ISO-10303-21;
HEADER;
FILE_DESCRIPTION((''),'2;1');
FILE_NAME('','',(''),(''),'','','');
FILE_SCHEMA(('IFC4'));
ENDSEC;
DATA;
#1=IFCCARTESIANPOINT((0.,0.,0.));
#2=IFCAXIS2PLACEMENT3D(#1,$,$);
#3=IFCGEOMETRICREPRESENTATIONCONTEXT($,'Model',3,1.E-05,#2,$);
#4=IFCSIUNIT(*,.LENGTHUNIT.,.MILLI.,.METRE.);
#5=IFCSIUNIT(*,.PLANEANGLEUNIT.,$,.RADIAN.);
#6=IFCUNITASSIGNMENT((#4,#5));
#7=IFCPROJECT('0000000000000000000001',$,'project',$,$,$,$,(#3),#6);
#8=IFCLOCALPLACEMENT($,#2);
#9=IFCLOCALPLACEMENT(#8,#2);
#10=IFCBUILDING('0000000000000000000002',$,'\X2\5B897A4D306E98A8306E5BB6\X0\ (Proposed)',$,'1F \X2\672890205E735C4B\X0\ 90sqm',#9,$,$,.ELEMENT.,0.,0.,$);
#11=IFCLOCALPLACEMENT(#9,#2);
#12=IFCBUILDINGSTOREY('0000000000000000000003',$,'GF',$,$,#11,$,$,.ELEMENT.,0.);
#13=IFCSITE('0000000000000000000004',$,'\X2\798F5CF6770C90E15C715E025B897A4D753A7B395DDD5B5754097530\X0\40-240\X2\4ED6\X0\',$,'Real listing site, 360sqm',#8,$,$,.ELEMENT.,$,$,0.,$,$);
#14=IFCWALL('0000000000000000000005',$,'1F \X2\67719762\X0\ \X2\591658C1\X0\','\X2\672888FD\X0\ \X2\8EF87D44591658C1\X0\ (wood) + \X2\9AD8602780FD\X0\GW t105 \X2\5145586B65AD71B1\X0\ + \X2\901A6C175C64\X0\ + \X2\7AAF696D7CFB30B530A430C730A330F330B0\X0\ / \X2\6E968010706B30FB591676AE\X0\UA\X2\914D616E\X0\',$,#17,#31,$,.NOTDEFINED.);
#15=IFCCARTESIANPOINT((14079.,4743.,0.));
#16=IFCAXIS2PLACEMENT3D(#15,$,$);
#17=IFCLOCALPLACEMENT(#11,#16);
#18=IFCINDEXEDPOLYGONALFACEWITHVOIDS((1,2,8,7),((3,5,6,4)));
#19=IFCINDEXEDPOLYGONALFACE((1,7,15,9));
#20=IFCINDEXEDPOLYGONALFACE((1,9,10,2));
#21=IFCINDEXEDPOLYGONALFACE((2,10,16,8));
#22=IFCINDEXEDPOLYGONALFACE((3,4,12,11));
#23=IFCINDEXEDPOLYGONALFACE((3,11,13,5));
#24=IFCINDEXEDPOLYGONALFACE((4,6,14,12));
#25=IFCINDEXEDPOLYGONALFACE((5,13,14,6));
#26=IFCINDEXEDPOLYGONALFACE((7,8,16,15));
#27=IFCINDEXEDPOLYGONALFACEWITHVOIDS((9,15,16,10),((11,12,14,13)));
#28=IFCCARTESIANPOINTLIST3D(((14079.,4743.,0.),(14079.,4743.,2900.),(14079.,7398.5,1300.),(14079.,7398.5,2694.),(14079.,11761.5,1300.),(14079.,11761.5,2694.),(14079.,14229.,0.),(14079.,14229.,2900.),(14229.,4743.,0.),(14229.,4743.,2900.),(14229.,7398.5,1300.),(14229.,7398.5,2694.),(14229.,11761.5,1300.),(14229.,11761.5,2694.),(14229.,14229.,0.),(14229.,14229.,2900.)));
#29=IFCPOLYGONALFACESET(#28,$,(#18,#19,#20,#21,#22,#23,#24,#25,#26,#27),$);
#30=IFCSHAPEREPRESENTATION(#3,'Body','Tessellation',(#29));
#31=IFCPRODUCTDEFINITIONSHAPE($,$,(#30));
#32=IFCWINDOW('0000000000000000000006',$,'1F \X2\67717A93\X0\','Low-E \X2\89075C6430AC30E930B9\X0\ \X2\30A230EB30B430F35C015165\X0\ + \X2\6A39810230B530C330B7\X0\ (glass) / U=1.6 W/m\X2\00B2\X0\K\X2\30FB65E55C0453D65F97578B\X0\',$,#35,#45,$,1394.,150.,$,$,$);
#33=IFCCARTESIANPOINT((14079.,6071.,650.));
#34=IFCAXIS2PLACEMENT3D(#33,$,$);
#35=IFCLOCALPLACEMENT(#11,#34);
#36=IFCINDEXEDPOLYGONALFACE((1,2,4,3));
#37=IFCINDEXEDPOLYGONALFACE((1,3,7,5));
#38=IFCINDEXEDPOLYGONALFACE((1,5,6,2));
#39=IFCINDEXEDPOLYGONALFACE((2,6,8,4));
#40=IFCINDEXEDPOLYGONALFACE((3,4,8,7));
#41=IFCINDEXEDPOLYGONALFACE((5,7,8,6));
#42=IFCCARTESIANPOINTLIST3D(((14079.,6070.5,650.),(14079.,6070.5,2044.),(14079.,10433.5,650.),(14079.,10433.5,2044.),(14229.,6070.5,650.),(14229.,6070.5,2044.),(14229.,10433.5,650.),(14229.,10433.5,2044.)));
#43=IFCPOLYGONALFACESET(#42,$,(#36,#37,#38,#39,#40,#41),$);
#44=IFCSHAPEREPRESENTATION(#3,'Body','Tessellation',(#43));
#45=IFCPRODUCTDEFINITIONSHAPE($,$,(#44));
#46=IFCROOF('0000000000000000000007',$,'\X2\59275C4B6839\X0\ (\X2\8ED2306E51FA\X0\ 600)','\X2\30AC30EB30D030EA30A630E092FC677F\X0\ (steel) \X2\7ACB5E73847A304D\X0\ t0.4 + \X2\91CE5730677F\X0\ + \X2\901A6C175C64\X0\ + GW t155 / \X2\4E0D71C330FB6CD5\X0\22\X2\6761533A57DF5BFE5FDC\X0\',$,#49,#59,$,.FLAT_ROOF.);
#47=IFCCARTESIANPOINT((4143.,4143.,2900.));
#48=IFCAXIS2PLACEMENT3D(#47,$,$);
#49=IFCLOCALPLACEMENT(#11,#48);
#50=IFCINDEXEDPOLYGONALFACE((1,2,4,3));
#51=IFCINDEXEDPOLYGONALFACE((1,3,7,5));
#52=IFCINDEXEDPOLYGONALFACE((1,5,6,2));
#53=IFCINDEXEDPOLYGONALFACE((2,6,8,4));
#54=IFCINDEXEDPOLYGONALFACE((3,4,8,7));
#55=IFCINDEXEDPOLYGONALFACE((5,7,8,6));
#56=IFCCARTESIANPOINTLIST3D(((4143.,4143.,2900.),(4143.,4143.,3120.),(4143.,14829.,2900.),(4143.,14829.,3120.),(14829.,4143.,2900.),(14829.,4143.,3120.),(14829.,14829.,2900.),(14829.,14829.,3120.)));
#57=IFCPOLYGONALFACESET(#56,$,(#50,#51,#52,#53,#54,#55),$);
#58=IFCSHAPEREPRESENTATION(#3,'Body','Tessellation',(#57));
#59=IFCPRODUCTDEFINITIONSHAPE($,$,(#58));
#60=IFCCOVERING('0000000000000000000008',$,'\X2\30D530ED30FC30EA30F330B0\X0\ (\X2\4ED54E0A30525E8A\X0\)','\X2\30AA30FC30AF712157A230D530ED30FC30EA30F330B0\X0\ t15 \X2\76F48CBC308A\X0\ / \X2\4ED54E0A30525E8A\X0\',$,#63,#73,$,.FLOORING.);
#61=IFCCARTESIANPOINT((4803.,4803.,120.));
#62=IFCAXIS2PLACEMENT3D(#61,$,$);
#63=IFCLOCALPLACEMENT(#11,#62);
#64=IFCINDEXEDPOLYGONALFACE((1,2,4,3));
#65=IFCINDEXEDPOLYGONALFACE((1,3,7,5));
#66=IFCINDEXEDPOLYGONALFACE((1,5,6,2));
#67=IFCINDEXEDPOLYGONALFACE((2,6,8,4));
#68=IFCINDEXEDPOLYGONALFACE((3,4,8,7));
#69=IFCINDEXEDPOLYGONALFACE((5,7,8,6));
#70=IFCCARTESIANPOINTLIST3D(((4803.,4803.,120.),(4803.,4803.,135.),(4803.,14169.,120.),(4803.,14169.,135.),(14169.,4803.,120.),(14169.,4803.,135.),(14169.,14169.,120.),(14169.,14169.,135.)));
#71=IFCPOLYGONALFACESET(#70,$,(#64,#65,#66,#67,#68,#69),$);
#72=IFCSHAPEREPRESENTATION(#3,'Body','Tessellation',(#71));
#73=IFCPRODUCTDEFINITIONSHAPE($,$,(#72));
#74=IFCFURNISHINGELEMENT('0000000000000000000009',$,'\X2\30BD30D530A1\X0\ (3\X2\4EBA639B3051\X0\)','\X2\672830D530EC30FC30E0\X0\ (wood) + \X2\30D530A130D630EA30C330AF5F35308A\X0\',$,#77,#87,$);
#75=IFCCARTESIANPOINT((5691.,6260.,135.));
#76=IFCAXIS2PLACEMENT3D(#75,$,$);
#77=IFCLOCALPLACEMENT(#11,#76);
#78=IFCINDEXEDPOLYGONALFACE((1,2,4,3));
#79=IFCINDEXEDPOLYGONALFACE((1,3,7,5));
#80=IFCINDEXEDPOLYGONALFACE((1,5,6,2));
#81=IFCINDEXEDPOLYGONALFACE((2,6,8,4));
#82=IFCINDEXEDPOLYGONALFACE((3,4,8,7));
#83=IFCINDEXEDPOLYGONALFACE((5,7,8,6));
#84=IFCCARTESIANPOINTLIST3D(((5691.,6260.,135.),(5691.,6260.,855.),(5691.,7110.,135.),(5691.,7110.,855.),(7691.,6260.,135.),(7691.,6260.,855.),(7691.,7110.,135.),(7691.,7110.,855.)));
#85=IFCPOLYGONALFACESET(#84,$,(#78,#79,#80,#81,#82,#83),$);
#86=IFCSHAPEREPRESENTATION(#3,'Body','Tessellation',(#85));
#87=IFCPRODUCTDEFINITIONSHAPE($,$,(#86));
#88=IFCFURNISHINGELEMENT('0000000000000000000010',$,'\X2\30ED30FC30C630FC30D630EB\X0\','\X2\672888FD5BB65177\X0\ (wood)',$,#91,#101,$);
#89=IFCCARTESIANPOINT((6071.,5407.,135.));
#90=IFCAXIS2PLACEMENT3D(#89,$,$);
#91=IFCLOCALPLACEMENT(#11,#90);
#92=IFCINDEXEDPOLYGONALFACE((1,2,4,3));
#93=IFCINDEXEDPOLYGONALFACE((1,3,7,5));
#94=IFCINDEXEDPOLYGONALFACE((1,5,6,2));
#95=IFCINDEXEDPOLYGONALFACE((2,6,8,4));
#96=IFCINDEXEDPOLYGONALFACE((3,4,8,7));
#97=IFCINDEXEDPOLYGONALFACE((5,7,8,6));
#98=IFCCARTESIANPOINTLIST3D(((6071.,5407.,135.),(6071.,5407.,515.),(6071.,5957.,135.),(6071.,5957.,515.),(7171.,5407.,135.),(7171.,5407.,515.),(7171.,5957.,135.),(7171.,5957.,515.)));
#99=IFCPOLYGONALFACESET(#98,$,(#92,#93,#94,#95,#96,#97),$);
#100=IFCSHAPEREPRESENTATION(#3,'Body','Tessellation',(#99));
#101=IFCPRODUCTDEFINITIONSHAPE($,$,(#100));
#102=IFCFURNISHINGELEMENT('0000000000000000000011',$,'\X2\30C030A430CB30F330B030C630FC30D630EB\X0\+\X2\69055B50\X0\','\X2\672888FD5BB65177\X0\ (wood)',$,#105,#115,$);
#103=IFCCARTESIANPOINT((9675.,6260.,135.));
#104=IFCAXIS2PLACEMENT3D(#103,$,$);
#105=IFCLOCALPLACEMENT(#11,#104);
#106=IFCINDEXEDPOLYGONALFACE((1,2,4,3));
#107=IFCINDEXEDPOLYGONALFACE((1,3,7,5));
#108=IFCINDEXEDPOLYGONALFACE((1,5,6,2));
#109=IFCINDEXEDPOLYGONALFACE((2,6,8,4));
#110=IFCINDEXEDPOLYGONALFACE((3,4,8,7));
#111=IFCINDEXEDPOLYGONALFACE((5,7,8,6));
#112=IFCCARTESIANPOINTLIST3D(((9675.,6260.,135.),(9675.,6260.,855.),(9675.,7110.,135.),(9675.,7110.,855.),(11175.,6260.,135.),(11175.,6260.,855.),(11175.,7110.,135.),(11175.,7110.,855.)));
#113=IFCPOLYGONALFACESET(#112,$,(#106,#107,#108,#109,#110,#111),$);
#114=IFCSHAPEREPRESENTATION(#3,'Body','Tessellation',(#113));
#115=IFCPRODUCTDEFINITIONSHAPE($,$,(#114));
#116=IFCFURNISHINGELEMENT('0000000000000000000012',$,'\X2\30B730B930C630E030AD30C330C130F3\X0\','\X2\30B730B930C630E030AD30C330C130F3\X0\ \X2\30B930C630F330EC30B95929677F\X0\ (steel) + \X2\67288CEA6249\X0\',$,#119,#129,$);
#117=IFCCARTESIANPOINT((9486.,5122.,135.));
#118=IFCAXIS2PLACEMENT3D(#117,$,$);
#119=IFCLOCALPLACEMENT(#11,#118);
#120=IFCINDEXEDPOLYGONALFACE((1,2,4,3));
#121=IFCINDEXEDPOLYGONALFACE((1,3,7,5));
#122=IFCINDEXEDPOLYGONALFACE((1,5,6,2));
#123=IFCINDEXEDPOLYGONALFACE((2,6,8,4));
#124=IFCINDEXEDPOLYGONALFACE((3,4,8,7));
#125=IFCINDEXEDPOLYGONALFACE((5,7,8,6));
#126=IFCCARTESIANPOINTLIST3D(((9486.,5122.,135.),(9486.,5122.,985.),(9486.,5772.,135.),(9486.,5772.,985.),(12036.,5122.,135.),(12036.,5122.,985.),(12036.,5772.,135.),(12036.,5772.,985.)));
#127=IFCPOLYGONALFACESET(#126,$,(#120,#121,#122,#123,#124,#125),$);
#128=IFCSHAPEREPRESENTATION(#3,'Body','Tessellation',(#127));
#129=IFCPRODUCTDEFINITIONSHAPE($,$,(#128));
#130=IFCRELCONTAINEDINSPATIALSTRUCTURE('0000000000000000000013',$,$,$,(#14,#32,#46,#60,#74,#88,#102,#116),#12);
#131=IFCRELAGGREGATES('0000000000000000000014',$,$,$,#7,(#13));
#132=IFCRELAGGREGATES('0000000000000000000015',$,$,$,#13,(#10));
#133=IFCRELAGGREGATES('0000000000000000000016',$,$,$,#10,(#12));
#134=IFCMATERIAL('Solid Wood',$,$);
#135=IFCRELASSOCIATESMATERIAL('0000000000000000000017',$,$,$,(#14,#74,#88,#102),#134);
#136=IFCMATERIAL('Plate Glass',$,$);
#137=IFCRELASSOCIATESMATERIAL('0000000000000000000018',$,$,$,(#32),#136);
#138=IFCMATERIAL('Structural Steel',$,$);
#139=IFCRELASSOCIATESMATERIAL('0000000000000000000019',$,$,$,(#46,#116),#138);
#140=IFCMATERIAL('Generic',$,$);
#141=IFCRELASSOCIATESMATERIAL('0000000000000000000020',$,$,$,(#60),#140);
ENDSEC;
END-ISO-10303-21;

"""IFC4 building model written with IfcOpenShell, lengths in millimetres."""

from ifc_helpers import new_model, si_unit, frame, frame_2d, origin, place, context, project, spatial, rectangle, extrude, material, element, fill, save


model = new_model("IFC4")

# Units and contexts
model_context = context("Model", 3, precision=1e-05, world=origin())
ifc_project = project(units=[si_unit("LENGTHUNIT", "METRE", prefix="MILLI"), si_unit("PLANEANGLEUNIT", "RADIAN")], contexts=[model_context])

# Site, building, storey
site_placement = place(None, origin())
site = spatial("IfcSite", under=ifc_project, at=site_placement, Name="福島県郡山市安積町笹川字吉田40-240他", ObjectType="Real listing site, 360sqm", CompositionType="ELEMENT", RefElevation=0.0)
building_placement = place(site_placement, origin())
building = spatial("IfcBuilding", under=site, at=building_placement, Name="安積の風の家 (Proposed)", ObjectType="1F 木造平屋 90sqm", CompositionType="ELEMENT", ElevationOfRefHeight=0.0, ElevationOfTerrain=0.0)
storey_placement = place(building_placement, origin())
storey = spatial("IfcBuildingStorey", under=building, at=storey_placement, Name="GF", CompositionType="ELEMENT", Elevation=0.0)

# Shared definitions
ifc_material_1 = material(Name="Solid Wood")

# Shared definitions
ifc_material_2 = material(Name="Plate Glass")

# Wall, opening, window
wall_1_placement = place(storey_placement, frame((14079.0, 4743.0, 0.0)))
wall_1 = element("IfcWall", 1, at=wall_1_placement, inside=storey, material=ifc_material_1, Name="1F 東面 外壁", Description="木製 軸組外壁 (wood) + 高性能GW t105 充填断熱 + 通気層 + 窯業系サイディング / 準耐火・外皮UA配慮", PredefinedType="NOTDEFINED", context=model_context, shape_type="SweptSolid", body=[
    extrude(rectangle(XDim=150.0, YDim=9486.0, at=frame_2d((75.0, 4743.0))), frame((14079.0, 4743.0, 0.0)), (0.0, 0.0, 1.0), 2900.0),
])
opening_1_placement = place(storey_placement, frame((14079.0, 6071.0, 650.0)))
opening_1 = element("IfcOpeningElement", 2, at=opening_1_placement, cuts=wall_1, PredefinedType="NOTDEFINED", context=model_context, shape_type="SweptSolid", body=[
    extrude(rectangle(XDim=150.0, YDim=4363.0, at=frame_2d((75.0, 2181.0))), frame((14079.0, 6071.0, 650.0)), (0.0, 0.0, 1.0), 1394.0),
])
window_1_placement = place(storey_placement, frame((14079.0, 6071.0, 650.0)))
window_1 = element("IfcWindow", 3, at=window_1_placement, inside=storey, material=ifc_material_2, Name="1F 東窓", Description="Low-E 複層ガラス アルゴン封入 + 樹脂サッシ (glass) / U=1.6 W/m²K・日射取得型", OverallHeight=1394.0, OverallWidth=150.0, context=model_context, shape_type="SweptSolid", body=[
    extrude(rectangle(XDim=150.0, YDim=4363.0, at=frame_2d((75.0, 2181.0))), frame((14079.0, 6071.0, 650.0)), (0.0, 0.0, 1.0), 1394.0),
])
fill(opening_1, window_1)

# Roof
ifc_material_3 = material(Name="Structural Steel")
roof_placement = place(storey_placement, frame((4143.0, 4143.0, 2900.0)))
element("IfcRoof", 4, at=roof_placement, inside=storey, material=ifc_material_3, Name="大屋根 (軒の出 600)", Description="ガルバリウム鋼板 (steel) 立平葺き t0.4 + 野地板 + 通気層 + GW t155 / 不燃・法22条区域対応", PredefinedType="FLAT_ROOF", context=model_context, shape_type="SweptSolid", body=[
    extrude(rectangle(XDim=10686.0, YDim=10686.0, at=frame_2d((5343.0, 5343.0))), frame((4143.0, 4143.0, 2900.0)), (0.0, 0.0, 1.0), 220.0),
])

# Covering
ifc_material_4 = material(Name="Generic")
covering_placement = place(storey_placement, frame((4803.0, 4803.0, 120.0)))
element("IfcCovering", 5, at=covering_placement, inside=storey, material=ifc_material_4, Name="フローリング (仕上げ床)", Description="オーク無垢フローリング t15 直貼り / 仕上げ床", PredefinedType="FLOORING", context=model_context, shape_type="SweptSolid", body=[
    extrude(rectangle(XDim=9366.0, YDim=9366.0, at=frame_2d((4683.0, 4683.0))), frame((4803.0, 4803.0, 120.0)), (0.0, 0.0, 1.0), 15.0),
])

# Furnishing elements
furnishing_1_placement = place(storey_placement, frame((5691.0, 6260.0, 135.0)))
element("IfcFurnishingElement", 6, at=furnishing_1_placement, inside=storey, material=ifc_material_1, Name="ソファ (3人掛け)", Description="木フレーム (wood) + ファブリック張り", context=model_context, shape_type="SweptSolid", body=[
    extrude(rectangle(XDim=2000.0, YDim=850.0, at=frame_2d((1000.0, 425.0))), frame((5691.0, 6260.0, 135.0)), (0.0, 0.0, 1.0), 720.0),
])
furnishing_2_placement = place(storey_placement, frame((6071.0, 5407.0, 135.0)))
element("IfcFurnishingElement", 7, at=furnishing_2_placement, inside=storey, material=ifc_material_1, Name="ローテーブル", Description="木製家具 (wood)", context=model_context, shape_type="SweptSolid", body=[
    extrude(rectangle(XDim=1100.0, YDim=550.0, at=frame_2d((550.0, 275.0))), frame((6071.0, 5407.0, 135.0)), (0.0, 0.0, 1.0), 380.0),
])
furnishing_3_placement = place(storey_placement, frame((9675.0, 6260.0, 135.0)))
element("IfcFurnishingElement", 8, at=furnishing_3_placement, inside=storey, material=ifc_material_1, Name="ダイニングテーブル+椅子", Description="木製家具 (wood)", context=model_context, shape_type="SweptSolid", body=[
    extrude(rectangle(XDim=1500.0, YDim=850.0, at=frame_2d((750.0, 425.0))), frame((9675.0, 6260.0, 135.0)), (0.0, 0.0, 1.0), 720.0),
])
furnishing_4_placement = place(storey_placement, frame((9486.0, 5122.0, 135.0)))
element("IfcFurnishingElement", 9, at=furnishing_4_placement, inside=storey, material=ifc_material_3, Name="システムキッチン", Description="システムキッチン ステンレス天板 (steel) + 木質扉", context=model_context, shape_type="SweptSolid", body=[
    extrude(rectangle(XDim=2550.0, YDim=650.0, at=frame_2d((1275.0, 325.0))), frame((9486.0, 5122.0, 135.0)), (0.0, 0.0, 1.0), 850.0),
])

save(model, "model.ifc")
